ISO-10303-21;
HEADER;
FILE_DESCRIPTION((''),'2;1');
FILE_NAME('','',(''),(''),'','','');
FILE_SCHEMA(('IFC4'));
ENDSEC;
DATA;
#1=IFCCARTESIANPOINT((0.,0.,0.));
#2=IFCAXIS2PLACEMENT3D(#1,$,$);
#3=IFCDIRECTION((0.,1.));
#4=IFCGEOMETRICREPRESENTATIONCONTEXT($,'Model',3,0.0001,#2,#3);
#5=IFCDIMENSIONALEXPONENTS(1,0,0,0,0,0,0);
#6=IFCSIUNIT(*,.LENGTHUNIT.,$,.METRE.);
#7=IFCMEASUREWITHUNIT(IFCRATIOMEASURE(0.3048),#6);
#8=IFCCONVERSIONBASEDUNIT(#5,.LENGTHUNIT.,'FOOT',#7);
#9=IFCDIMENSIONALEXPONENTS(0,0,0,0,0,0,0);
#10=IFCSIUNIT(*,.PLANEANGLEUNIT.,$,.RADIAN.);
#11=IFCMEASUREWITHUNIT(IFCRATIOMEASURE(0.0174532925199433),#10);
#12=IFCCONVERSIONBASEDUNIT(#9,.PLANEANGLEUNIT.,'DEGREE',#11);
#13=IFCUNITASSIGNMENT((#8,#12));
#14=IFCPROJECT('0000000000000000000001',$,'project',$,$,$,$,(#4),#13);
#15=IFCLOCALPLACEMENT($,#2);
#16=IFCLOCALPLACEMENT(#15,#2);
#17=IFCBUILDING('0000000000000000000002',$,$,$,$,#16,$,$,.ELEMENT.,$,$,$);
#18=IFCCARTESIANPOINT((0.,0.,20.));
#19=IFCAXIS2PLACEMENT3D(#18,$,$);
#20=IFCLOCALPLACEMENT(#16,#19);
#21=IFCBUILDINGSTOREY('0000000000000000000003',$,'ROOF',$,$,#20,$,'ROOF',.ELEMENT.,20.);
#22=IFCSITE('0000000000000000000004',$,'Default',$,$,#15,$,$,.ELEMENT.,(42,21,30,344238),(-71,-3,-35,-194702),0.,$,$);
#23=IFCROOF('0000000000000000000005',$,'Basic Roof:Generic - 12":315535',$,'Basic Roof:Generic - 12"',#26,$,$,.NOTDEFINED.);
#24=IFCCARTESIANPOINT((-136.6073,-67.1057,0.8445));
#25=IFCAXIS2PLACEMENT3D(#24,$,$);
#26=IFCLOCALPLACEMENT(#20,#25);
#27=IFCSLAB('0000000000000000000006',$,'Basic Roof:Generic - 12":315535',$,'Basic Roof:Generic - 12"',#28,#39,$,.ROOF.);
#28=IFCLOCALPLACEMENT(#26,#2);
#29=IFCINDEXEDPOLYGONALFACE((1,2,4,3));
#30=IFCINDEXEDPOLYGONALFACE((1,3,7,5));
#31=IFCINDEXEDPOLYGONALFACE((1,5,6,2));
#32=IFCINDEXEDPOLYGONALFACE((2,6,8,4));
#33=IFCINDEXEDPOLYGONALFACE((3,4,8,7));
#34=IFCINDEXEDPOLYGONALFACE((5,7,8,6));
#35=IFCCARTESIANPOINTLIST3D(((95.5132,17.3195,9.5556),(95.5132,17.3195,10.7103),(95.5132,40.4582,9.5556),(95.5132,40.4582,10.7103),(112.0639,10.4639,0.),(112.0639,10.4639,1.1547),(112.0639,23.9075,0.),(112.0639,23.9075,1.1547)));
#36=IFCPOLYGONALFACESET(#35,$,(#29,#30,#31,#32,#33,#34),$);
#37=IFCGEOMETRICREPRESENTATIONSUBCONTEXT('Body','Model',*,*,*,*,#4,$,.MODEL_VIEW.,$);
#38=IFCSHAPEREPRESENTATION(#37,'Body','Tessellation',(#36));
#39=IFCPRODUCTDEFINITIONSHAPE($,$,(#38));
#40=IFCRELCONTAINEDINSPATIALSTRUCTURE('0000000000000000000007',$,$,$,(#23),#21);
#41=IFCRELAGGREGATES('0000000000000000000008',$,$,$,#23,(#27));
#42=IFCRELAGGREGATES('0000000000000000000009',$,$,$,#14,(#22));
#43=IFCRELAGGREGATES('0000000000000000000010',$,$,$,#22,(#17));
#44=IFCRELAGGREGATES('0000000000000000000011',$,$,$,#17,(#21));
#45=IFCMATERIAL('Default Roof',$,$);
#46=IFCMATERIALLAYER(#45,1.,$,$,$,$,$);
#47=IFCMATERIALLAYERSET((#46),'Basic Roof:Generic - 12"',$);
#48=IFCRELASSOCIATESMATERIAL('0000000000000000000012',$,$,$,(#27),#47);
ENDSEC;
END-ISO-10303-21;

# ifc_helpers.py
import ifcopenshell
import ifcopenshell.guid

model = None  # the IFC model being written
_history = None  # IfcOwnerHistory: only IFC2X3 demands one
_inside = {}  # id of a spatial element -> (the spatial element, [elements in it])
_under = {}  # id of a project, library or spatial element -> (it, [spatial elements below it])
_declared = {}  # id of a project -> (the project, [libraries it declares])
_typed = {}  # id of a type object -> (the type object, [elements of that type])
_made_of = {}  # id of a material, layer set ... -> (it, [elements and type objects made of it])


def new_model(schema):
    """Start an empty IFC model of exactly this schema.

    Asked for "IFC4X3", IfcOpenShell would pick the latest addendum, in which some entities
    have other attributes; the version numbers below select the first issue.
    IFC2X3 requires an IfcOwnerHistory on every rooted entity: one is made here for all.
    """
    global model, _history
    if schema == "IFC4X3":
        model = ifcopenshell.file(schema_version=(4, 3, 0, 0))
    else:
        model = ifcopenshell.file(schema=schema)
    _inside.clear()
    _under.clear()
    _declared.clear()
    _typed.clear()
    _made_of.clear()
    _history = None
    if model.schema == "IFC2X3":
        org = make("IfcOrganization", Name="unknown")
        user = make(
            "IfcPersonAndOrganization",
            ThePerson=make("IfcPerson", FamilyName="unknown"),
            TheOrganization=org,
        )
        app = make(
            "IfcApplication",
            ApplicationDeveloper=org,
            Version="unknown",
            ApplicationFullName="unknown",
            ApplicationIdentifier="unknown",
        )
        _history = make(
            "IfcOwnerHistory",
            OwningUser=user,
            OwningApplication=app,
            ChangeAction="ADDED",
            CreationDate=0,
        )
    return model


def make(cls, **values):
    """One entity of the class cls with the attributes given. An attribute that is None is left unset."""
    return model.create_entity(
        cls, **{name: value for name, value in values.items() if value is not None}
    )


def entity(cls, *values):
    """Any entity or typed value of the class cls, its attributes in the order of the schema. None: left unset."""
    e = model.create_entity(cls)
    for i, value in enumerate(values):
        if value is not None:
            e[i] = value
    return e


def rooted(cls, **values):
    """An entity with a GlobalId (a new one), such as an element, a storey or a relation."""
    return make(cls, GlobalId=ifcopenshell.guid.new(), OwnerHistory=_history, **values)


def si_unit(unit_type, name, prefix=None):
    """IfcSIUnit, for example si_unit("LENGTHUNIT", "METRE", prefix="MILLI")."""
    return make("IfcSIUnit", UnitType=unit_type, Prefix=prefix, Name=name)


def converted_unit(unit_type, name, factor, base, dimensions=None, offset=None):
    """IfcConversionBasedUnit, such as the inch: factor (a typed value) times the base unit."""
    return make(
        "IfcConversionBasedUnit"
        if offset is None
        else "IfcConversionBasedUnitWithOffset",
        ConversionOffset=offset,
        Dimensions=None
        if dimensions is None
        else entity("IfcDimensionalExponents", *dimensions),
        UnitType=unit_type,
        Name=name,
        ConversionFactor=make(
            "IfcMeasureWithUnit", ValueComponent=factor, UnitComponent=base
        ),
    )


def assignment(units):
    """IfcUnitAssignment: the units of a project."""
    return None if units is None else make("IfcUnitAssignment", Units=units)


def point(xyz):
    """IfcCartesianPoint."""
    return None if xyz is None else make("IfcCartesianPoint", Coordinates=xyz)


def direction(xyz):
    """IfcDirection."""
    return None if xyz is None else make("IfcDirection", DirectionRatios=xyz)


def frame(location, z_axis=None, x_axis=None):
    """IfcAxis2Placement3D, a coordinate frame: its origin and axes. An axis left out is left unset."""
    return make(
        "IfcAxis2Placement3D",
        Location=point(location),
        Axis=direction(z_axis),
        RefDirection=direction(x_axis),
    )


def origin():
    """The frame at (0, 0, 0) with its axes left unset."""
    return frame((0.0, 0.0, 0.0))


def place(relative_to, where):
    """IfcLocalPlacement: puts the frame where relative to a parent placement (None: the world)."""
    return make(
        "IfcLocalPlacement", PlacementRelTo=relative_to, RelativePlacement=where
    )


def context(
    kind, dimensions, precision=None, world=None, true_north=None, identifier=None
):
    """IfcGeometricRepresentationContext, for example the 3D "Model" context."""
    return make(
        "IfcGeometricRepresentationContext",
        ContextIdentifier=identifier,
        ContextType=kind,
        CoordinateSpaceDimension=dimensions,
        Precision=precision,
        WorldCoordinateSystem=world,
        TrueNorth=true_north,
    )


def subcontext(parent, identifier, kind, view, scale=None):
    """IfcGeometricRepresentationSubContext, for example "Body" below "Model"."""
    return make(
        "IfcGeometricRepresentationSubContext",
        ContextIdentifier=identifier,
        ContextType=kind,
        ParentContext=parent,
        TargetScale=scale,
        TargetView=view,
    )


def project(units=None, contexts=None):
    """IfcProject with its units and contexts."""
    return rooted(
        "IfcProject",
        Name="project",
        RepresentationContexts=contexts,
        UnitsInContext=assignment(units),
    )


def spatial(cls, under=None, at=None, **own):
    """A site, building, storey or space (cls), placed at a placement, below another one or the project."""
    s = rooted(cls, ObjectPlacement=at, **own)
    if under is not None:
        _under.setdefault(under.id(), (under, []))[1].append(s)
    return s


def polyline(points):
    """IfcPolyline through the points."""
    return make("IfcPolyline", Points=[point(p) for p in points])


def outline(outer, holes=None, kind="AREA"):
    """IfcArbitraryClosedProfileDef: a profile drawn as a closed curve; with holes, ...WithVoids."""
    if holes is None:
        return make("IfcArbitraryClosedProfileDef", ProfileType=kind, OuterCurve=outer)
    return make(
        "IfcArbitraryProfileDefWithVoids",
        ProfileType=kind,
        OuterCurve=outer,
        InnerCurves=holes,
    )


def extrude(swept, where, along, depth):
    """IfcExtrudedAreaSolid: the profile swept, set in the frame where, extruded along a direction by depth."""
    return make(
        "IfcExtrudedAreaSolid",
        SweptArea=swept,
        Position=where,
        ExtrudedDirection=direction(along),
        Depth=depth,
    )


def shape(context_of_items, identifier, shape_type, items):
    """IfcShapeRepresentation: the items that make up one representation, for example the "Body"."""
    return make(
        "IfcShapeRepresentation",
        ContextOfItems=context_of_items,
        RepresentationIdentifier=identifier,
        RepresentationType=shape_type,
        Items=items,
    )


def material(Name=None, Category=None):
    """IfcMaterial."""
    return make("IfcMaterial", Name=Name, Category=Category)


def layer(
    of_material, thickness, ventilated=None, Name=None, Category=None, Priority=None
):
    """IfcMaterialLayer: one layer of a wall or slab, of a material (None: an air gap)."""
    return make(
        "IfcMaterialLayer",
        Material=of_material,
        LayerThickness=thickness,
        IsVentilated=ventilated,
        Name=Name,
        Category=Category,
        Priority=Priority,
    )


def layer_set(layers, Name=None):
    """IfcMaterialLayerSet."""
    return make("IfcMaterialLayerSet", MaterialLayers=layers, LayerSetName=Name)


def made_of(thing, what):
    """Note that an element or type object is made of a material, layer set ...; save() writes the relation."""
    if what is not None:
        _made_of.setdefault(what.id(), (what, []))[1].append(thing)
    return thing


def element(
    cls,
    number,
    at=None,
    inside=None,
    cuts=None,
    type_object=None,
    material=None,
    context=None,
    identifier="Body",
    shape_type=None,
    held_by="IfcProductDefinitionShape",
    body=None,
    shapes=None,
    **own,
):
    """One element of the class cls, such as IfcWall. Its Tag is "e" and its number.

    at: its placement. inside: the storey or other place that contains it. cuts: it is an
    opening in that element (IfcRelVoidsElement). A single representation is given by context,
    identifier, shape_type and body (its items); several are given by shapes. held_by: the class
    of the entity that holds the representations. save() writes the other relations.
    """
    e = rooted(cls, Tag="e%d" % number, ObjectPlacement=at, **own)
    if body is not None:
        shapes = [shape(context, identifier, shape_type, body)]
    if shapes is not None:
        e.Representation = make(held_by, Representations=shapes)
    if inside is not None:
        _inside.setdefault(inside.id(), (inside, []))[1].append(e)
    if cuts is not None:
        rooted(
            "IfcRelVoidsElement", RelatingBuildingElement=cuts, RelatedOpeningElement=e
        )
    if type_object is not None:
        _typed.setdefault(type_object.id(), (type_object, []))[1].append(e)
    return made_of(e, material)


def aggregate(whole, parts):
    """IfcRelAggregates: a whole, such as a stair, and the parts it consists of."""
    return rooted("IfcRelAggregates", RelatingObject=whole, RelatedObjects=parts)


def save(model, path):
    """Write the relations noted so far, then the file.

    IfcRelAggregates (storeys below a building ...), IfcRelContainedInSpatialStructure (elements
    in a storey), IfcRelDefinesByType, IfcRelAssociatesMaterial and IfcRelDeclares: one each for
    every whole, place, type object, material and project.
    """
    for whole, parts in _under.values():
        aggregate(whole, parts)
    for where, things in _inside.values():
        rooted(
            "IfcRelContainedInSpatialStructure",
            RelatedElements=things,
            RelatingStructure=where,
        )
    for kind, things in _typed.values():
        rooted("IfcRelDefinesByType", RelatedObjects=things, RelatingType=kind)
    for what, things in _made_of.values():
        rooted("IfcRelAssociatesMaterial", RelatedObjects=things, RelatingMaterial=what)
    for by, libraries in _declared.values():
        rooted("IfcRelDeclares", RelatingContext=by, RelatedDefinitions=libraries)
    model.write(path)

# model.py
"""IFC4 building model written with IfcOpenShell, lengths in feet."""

from ifc_helpers import new_model, entity, si_unit, converted_unit, direction, frame, origin, place, context, subcontext, project, spatial, polyline, outline, extrude, material, layer, layer_set, element, aggregate, save


model = new_model("IFC4")

# Units and contexts
model_context = context("Model", 3, precision=0.0001, world=origin(), true_north=direction((0.0, 1.0)))
body_context = subcontext(model_context, "Body", "Model", "MODEL_VIEW")
ifc_project = project(units=[converted_unit("LENGTHUNIT", "FOOT", entity("IfcRatioMeasure", 0.3048), si_unit("LENGTHUNIT", "METRE"), dimensions=[1, 0, 0, 0, 0, 0, 0]), converted_unit("PLANEANGLEUNIT", "DEGREE", entity("IfcRatioMeasure", 0.0174532925199433), si_unit("PLANEANGLEUNIT", "RADIAN"), dimensions=[0, 0, 0, 0, 0, 0, 0])], contexts=[model_context])

# Site, building, storey
site_placement = place(None, origin())
site = spatial("IfcSite", under=ifc_project, at=site_placement, Name="Default", CompositionType="ELEMENT", RefLatitude=(42, 21, 30, 344238), RefLongitude=(-71, -3, -35, -194702), RefElevation=0.0)
building_placement = place(site_placement, origin())
building = spatial("IfcBuilding", under=site, at=building_placement, CompositionType="ELEMENT")
storey_placement = place(building_placement, frame((0.0, 0.0, 20.0)))
storey = spatial("IfcBuildingStorey", under=building, at=storey_placement, Name="ROOF", LongName="ROOF", CompositionType="ELEMENT", Elevation=20.0)

# Roof, slab
roof_placement = place(storey_placement, frame((-136.6073, -67.1057, 0.8445)))
roof = element("IfcRoof", 1, at=roof_placement, inside=storey, Name="Basic Roof:Generic - 12\":315535", ObjectType="Basic Roof:Generic - 12\"", PredefinedType="NOTDEFINED")
ifc_material = material(Name="Default Roof")
ifc_layer = layer(ifc_material, 1.0)
ifc_layer_set = layer_set([ifc_layer], Name="Basic Roof:Generic - 12\"")
slab_1_placement = place(roof_placement, origin())
slab_1 = element("IfcSlab", 2, at=slab_1_placement, material=ifc_layer_set, Name="Basic Roof:Generic - 12\":315535", ObjectType="Basic Roof:Generic - 12\"", PredefinedType="ROOF", context=body_context, shape_type="SweptSolid", body=[
    extrude(outline(polyline([(9.5556, -14.9971), (9.5556, -1.5536), (-9.5556, 14.9971), (-9.5556, -8.1416), (9.5556, -14.9971)])), frame((103.7886, 25.4611, 4.7778), z_axis=(0.5, 0.0, 0.866025), x_axis=(0.866025, 0.0, -0.5)), (-0.5, 0.0, 0.866025), 1.1547),
])
aggregate(roof, [slab_1])

save(model, "model.ifc")
